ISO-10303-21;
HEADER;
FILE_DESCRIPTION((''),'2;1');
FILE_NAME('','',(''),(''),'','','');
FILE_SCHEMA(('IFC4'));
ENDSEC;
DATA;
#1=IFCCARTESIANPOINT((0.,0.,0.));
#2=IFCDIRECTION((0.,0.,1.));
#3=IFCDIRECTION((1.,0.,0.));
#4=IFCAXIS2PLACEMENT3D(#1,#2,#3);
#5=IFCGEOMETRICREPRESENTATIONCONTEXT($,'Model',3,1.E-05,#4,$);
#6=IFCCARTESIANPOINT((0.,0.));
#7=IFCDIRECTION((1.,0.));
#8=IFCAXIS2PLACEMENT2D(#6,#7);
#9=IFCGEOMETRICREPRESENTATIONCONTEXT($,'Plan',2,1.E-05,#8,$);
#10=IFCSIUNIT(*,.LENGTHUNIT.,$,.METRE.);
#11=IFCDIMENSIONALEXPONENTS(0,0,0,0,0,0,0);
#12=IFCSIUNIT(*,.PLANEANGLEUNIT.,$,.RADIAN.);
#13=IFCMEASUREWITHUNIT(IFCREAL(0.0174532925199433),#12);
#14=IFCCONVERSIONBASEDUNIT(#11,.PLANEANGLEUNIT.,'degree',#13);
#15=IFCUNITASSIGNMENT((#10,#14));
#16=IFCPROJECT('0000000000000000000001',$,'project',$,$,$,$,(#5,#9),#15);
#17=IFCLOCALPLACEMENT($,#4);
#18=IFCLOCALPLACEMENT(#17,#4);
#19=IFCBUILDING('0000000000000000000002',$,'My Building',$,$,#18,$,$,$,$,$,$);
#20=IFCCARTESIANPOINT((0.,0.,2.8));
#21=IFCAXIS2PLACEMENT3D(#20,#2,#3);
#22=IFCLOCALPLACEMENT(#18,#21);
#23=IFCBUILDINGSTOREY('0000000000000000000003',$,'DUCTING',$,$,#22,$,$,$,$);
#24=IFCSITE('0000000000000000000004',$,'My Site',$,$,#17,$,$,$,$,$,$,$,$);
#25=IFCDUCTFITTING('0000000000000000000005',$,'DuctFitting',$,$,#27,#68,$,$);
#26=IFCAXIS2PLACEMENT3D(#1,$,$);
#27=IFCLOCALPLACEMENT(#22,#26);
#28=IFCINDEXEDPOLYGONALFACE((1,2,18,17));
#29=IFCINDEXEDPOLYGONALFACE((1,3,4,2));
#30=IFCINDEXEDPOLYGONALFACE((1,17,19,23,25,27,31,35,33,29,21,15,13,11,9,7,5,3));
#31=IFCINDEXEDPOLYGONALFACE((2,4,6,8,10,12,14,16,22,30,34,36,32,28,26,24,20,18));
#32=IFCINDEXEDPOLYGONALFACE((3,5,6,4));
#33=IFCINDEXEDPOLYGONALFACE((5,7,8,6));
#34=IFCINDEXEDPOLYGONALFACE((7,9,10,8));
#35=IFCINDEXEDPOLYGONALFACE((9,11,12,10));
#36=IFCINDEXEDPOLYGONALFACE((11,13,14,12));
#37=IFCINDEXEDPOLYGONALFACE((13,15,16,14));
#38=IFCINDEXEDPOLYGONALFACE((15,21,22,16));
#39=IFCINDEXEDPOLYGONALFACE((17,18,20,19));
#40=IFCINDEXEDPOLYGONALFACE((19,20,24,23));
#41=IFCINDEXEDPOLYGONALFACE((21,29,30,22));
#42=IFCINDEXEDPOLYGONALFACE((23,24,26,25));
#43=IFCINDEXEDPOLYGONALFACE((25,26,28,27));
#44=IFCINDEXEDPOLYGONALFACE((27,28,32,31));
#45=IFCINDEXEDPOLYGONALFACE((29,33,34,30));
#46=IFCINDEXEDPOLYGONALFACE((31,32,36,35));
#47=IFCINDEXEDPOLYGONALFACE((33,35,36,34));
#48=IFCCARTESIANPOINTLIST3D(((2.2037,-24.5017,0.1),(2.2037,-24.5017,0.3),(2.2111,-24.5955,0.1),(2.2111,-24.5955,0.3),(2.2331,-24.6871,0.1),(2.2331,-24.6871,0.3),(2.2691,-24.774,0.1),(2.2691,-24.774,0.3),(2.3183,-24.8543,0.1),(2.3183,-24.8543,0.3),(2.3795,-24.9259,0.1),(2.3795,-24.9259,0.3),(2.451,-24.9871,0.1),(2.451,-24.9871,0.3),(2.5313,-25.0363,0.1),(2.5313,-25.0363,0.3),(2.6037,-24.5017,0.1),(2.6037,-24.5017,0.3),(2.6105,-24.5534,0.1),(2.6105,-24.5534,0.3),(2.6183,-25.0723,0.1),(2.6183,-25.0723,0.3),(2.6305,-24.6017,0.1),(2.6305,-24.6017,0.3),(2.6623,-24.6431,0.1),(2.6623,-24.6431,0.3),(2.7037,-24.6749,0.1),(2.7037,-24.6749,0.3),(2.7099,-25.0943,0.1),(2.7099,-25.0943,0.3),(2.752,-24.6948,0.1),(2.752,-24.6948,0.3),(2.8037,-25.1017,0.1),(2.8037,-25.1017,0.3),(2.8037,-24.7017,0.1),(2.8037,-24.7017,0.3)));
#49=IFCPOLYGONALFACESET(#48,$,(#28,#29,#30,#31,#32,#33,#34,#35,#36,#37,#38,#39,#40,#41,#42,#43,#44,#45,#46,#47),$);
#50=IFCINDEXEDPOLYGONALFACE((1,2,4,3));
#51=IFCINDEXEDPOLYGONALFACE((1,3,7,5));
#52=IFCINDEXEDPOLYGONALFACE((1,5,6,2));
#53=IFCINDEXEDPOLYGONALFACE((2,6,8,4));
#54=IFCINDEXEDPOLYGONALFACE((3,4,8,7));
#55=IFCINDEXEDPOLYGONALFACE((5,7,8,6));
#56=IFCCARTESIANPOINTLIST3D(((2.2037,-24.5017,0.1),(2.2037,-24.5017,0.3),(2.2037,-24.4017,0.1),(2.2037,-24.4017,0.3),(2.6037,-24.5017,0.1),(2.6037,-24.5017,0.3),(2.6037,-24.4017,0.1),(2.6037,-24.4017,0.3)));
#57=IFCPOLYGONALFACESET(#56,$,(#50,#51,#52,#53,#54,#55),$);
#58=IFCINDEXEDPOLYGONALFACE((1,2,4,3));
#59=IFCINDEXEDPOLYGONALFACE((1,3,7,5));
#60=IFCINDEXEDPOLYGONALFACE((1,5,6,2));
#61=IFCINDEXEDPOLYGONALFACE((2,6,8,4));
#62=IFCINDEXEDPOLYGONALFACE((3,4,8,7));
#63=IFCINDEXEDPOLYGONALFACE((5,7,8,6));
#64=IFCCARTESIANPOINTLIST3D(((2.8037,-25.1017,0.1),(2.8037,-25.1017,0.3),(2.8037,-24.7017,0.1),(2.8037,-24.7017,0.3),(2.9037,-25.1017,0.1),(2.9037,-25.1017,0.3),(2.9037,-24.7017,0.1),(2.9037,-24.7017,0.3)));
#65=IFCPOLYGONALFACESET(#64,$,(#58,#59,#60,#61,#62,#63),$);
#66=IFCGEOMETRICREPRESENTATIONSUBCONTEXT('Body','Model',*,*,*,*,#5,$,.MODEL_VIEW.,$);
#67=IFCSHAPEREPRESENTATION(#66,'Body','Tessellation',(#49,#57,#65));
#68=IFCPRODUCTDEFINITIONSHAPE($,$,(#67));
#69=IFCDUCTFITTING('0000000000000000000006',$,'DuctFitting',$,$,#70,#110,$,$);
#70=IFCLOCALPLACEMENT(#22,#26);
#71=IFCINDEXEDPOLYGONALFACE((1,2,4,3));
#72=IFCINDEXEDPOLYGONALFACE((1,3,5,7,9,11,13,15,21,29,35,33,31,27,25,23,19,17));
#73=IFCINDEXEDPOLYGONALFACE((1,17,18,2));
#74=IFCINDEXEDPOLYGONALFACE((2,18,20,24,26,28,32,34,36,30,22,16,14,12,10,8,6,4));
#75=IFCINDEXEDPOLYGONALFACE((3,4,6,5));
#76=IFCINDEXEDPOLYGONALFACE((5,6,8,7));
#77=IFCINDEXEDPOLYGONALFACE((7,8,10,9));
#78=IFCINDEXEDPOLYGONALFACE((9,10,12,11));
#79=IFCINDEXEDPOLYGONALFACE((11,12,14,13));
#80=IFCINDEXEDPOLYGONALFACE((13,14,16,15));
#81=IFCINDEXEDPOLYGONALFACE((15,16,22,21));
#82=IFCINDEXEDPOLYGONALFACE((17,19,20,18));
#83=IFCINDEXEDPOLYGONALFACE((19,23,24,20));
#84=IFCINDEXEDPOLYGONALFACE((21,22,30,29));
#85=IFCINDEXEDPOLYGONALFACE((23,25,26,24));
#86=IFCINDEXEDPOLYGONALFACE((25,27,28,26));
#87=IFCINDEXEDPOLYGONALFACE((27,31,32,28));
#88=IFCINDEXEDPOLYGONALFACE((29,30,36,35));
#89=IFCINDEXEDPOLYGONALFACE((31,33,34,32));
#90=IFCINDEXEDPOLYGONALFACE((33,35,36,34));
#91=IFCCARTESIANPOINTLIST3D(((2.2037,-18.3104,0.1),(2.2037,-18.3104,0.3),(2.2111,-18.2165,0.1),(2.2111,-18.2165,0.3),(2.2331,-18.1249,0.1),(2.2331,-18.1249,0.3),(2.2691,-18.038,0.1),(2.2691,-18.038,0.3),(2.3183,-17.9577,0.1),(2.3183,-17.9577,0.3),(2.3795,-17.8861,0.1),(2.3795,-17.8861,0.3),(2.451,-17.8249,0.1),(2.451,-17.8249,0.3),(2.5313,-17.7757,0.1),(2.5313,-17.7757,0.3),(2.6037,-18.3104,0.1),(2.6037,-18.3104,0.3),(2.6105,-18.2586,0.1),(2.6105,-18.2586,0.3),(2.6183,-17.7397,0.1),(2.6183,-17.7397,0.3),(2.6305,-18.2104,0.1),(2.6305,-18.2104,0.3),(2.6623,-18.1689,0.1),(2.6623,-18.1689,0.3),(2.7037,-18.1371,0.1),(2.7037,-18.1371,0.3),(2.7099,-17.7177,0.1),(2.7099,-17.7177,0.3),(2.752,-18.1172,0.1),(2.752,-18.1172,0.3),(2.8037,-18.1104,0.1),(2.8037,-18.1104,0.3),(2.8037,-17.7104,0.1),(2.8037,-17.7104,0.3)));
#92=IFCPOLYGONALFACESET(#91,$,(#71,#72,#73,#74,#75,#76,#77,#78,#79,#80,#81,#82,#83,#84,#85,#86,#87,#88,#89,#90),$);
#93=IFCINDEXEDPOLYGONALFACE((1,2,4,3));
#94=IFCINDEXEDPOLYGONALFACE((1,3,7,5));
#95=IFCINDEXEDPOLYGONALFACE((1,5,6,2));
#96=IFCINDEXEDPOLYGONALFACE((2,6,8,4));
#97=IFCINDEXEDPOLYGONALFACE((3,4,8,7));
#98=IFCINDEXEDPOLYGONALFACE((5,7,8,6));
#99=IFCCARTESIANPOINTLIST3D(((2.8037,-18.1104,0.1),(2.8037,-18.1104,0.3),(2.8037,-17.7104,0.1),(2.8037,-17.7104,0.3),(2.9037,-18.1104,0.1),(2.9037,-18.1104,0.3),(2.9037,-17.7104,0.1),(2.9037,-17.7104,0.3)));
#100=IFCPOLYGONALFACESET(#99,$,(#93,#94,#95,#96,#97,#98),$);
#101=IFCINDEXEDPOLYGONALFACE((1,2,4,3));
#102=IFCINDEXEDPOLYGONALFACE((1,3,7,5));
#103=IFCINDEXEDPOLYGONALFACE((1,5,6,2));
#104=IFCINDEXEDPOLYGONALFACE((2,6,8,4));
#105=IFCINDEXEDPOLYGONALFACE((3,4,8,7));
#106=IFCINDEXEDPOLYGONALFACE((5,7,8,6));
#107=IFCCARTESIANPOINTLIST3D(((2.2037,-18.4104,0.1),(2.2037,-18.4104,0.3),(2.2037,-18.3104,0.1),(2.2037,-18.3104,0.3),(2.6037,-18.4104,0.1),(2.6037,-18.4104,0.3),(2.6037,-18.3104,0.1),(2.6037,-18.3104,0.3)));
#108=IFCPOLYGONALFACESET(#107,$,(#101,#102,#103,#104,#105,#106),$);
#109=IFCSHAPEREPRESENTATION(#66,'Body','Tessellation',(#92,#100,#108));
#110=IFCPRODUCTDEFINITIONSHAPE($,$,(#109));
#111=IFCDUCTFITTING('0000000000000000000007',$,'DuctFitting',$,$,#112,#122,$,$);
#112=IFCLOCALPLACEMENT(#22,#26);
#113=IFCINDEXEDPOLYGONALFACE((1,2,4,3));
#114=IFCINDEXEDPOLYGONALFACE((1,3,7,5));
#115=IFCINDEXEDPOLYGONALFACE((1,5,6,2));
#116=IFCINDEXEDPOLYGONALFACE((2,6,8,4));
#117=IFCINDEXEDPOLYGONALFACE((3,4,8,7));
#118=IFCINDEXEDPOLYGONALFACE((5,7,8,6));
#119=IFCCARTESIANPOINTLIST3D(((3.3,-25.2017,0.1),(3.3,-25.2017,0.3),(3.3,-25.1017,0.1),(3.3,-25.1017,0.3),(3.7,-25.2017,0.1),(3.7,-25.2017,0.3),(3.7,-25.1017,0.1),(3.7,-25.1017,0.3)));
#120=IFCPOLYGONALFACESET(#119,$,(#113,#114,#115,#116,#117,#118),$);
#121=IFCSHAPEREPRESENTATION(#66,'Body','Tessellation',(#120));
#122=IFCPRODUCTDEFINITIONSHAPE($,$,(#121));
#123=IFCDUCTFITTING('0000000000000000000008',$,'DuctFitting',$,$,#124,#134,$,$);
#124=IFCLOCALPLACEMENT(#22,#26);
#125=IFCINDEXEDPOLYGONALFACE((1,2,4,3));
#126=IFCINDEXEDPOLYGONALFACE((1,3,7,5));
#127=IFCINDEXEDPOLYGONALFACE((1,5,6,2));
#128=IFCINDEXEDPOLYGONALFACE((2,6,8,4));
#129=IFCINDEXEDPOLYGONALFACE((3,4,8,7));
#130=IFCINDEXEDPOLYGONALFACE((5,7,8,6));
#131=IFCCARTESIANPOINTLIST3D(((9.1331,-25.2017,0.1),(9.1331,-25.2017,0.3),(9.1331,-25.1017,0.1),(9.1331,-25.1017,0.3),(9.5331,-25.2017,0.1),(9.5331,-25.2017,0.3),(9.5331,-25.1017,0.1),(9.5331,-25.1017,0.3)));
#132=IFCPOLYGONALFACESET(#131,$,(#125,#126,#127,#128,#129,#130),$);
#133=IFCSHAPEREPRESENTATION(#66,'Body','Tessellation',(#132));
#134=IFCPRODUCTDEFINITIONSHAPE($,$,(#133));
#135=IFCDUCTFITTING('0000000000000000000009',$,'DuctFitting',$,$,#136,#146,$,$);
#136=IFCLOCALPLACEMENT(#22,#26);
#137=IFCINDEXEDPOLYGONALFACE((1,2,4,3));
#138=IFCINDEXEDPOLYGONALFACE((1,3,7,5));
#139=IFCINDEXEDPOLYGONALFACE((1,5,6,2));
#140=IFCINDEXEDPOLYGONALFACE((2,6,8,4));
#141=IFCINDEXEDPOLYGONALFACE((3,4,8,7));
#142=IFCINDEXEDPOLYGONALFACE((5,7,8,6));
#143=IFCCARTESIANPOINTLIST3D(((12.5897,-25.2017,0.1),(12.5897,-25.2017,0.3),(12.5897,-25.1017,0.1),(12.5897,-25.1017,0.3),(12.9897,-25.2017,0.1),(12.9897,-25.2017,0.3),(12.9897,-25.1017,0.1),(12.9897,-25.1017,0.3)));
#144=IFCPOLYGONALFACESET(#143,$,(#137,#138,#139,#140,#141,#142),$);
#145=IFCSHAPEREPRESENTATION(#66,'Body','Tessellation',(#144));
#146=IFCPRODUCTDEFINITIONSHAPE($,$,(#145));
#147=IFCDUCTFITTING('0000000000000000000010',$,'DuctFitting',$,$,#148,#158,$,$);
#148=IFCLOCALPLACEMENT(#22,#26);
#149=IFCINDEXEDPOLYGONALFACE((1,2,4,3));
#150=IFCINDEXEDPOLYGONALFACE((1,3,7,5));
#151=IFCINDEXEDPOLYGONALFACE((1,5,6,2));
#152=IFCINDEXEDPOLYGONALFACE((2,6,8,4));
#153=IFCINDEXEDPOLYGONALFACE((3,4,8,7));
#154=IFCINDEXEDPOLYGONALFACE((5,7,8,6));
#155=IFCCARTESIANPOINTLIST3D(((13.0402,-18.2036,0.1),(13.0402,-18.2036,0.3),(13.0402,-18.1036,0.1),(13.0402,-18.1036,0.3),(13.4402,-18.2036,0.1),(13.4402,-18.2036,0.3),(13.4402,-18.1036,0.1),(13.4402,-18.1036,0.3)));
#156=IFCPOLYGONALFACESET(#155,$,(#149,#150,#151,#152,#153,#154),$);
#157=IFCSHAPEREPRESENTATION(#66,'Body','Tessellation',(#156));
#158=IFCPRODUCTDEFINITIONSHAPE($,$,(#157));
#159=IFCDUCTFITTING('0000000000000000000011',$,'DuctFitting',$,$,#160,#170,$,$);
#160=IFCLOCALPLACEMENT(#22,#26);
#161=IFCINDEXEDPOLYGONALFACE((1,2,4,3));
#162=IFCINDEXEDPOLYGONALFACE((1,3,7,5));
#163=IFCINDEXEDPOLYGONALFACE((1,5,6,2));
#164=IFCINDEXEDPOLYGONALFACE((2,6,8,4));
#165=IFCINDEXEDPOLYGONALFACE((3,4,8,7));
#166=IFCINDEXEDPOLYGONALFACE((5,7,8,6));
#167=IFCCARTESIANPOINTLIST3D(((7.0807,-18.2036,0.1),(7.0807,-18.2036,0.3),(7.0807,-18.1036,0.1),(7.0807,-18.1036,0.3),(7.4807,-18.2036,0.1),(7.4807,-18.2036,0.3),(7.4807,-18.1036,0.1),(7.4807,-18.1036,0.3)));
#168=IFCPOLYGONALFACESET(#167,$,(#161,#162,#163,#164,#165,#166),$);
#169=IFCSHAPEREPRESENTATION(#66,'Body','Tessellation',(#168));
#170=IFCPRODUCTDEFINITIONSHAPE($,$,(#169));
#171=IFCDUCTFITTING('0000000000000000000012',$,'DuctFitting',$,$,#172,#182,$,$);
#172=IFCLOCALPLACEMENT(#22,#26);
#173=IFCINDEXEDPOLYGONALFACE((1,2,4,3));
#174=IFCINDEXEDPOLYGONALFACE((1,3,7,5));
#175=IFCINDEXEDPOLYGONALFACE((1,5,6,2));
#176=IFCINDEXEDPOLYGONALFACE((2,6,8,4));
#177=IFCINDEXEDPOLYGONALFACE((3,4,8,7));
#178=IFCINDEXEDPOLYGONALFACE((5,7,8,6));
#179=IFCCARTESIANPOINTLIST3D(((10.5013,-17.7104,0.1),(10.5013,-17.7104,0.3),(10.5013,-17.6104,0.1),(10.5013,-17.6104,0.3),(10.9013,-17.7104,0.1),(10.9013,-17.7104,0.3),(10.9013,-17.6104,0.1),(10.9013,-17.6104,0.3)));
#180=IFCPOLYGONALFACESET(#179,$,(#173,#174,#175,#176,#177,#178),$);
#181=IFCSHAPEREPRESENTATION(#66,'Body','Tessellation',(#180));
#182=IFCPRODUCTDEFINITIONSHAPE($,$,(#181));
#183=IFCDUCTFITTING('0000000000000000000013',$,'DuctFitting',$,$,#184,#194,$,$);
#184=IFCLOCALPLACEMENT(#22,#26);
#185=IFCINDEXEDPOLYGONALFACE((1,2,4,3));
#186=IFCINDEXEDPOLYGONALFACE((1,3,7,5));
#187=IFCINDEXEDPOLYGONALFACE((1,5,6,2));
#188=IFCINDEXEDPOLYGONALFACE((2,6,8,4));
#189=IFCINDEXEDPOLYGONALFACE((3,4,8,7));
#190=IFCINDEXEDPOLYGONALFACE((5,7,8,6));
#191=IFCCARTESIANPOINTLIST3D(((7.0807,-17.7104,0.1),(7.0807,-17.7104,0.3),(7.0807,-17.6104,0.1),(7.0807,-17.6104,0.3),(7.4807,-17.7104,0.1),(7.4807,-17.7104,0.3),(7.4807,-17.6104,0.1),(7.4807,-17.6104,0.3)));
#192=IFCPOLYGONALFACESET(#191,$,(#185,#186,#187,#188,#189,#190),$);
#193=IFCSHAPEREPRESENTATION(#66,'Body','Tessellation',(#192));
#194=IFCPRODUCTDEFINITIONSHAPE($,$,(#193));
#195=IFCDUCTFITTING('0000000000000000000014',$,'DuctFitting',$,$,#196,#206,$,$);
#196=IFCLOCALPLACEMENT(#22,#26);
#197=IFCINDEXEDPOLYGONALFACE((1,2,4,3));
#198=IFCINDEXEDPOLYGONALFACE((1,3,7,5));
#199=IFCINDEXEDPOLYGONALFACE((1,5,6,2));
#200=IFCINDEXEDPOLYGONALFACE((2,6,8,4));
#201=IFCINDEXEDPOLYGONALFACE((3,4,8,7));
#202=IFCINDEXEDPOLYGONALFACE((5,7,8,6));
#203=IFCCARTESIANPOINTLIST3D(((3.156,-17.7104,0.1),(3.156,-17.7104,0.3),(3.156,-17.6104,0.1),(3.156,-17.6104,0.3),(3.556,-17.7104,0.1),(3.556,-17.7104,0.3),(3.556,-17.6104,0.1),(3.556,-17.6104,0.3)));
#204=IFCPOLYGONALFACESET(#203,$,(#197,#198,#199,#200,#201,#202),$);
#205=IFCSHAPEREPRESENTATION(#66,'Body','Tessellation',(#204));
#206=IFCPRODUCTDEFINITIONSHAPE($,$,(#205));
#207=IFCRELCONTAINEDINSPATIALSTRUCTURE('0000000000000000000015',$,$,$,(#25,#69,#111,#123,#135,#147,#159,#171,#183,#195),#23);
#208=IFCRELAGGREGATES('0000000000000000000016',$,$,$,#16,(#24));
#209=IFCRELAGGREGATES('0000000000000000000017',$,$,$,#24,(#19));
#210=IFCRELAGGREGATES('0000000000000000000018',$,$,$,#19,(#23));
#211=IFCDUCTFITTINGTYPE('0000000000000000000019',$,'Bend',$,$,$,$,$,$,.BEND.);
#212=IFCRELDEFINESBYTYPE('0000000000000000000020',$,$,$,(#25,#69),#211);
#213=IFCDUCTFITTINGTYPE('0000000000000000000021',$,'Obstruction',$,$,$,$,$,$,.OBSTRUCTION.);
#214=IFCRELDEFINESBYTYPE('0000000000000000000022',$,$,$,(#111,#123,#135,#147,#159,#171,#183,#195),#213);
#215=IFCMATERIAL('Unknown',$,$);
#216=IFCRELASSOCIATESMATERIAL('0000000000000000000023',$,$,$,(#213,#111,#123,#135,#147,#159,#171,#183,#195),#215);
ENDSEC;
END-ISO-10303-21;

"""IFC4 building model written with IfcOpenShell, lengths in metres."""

from ifc_helpers import new_model, entity, si_unit, converted_unit, frame, origin_with_axes, origin_2d_with_axis, place, context, subcontext, project, spatial, line, arc, indexed_curve, rectangle, outline, extrude, source, transform, mapped, material, material_profile, profile_set, profile_usage, type_object, type_shapes, element, save


model = new_model("IFC4")

# Units and contexts
model_context = context("Model", 3, precision=1e-05, world=origin_with_axes())
plan_context = context("Plan", 2, precision=1e-05, world=origin_2d_with_axis())
body_context = subcontext(model_context, "Body", "Model", "MODEL_VIEW")
ifc_project = project(units=[si_unit("LENGTHUNIT", "METRE"), converted_unit("PLANEANGLEUNIT", "degree", entity("IfcReal", 0.0174532925199433), si_unit("PLANEANGLEUNIT", "RADIAN"), dimensions=[0, 0, 0, 0, 0, 0, 0])], contexts=[model_context, plan_context])

# Site, building, storey
site_placement = place(None, origin_with_axes())
site = spatial("IfcSite", under=ifc_project, at=site_placement, Name="My Site")
building_placement = place(site_placement, origin_with_axes())
building = spatial("IfcBuilding", under=site, at=building_placement, Name="My Building")
storey_placement = place(building_placement, frame((0.0, 0.0, 2.8), z_axis=(0.0, 0.0, 1.0), x_axis=(1.0, 0.0, 0.0)))
storey = spatial("IfcBuildingStorey", under=building, at=storey_placement, Name="DUCTING")

# Shared definitions
ifc_material = material(Name="Unknown")

# Duct fittings
duct_fitting_type_1 = type_object("IfcDuctFittingType", Name="Bend", PredefinedType="BEND")
shared_shape = source(origin_with_axes(), body_context, "Body", "SweptSolid", [
    extrude(outline(indexed_curve([(0.2, 0.0), (0.2586, 0.1414), (0.4, 0.2), (0.4, 0.6), (-0.0243, 0.4243), (-0.2, 0.0)], segments=[arc(1, 2, 3), line(3, 4), arc(4, 5, 6), line(6, 1)])), frame((0.0, -0.1, 0.1), z_axis=(0.0, -1.0, 0.0), x_axis=(1.0, 0.0, 0.0)), (0.0, 0.0, -1.0), 0.2),
    extrude(rectangle(XDim=0.4, YDim=0.2), origin_with_axes(), (0.0, 0.0, 1.0), 0.1),
    extrude(rectangle(XDim=0.4, YDim=0.2), frame((0.4, 0.0, 0.5), z_axis=(1.0, 0.0, 0.0), x_axis=(0.0, 0.0, 1.0)), (0.0, 0.0, 1.0), 0.1),
])
type_shapes(duct_fitting_type_1, [shared_shape])
for number, where, z_axis, x_axis, name in (
    (1, (2.4037, -24.4017, 0.2), (0.0, -1.0, 0.0), (1.0, 0.0, 0.0), "DuctFitting"),
    (2, (2.9037, -17.9104, 0.2), (-1.0, 0.0, 0.0), (0.0, -1.0, 0.0), "DuctFitting"),
):
    element("IfcDuctFitting", number, at=place(storey_placement, frame(where, z_axis=z_axis, x_axis=x_axis)), inside=storey, type_object=duct_fitting_type_1, Name=name, context=body_context, shape_type="MappedRepresentation", body=[
        mapped(shared_shape, transform((0.0, 0.0, 0.0), x_axis=(1.0, 0.0, 0.0), y_axis=(0.0, 1.0, 0.0), z_axis=(0.0, 0.0, 1.0), scale=1.0)),
    ])
ifc_material_profile_1 = material_profile(ifc_material, rectangle(XDim=0.4, YDim=0.2))
ifc_profile_set_1 = profile_set([ifc_material_profile_1])
ifc_profile_usage_1 = profile_usage(ifc_profile_set_1, cardinal=5)
duct_fitting_type_2 = type_object("IfcDuctFittingType", Name="Obstruction", PredefinedType="OBSTRUCTION", material=ifc_profile_set_1)
duct_fitting_1_placement = place(storey_placement, frame((3.5, -25.1017, 0.2), z_axis=(0.0, -1.0, 0.0), x_axis=(1.0, 0.0, 0.0)))
element("IfcDuctFitting", 3, at=duct_fitting_1_placement, inside=storey, type_object=duct_fitting_type_2, material=ifc_profile_usage_1, Name="DuctFitting", context=body_context, shape_type="SweptSolid", body=[
    extrude(rectangle(XDim=0.4, YDim=0.2), origin_with_axes(), (0.0, 0.0, 1.0), 0.1),
])
ifc_profile_usage_2 = profile_usage(ifc_profile_set_1, cardinal=5)
duct_fitting_2_placement = place(storey_placement, frame((9.3331, -25.1017, 0.2), z_axis=(0.0, -1.0, 0.0), x_axis=(1.0, 0.0, 0.0)))
element("IfcDuctFitting", 4, at=duct_fitting_2_placement, inside=storey, type_object=duct_fitting_type_2, material=ifc_profile_usage_2, Name="DuctFitting", context=body_context, shape_type="SweptSolid", body=[
    extrude(rectangle(XDim=0.4, YDim=0.2), origin_with_axes(), (0.0, 0.0, 1.0), 0.1),
])
ifc_profile_usage_3 = profile_usage(ifc_profile_set_1, cardinal=5)
duct_fitting_3_placement = place(storey_placement, frame((12.7897, -25.1017, 0.2), z_axis=(0.0, -1.0, 0.0), x_axis=(1.0, 0.0, 0.0)))
element("IfcDuctFitting", 5, at=duct_fitting_3_placement, inside=storey, type_object=duct_fitting_type_2, material=ifc_profile_usage_3, Name="DuctFitting", context=body_context, shape_type="SweptSolid", body=[
    extrude(rectangle(XDim=0.4, YDim=0.2), origin_with_axes(), (0.0, 0.0, 1.0), 0.1),
])
ifc_profile_usage_4 = profile_usage(ifc_profile_set_1, cardinal=5)
duct_fitting_4_placement = place(storey_placement, frame((13.2402, -18.1036, 0.2), z_axis=(0.0, -1.0, 0.0), x_axis=(1.0, 0.0, 0.0)))
element("IfcDuctFitting", 6, at=duct_fitting_4_placement, inside=storey, type_object=duct_fitting_type_2, material=ifc_profile_usage_4, Name="DuctFitting", context=body_context, shape_type="SweptSolid", body=[
    extrude(rectangle(XDim=0.4, YDim=0.2), origin_with_axes(), (0.0, 0.0, 1.0), 0.1),
])
ifc_profile_usage_5 = profile_usage(ifc_profile_set_1, cardinal=5)
duct_fitting_5_placement = place(storey_placement, frame((7.2807, -18.1036, 0.2), z_axis=(0.0, -1.0, 0.0), x_axis=(1.0, 0.0, 0.0)))
element("IfcDuctFitting", 7, at=duct_fitting_5_placement, inside=storey, type_object=duct_fitting_type_2, material=ifc_profile_usage_5, Name="DuctFitting", context=body_context, shape_type="SweptSolid", body=[
    extrude(rectangle(XDim=0.4, YDim=0.2), origin_with_axes(), (0.0, 0.0, 1.0), 0.1),
])
ifc_profile_usage_6 = profile_usage(ifc_profile_set_1, cardinal=5)
duct_fitting_6_placement = place(storey_placement, frame((10.7013, -17.7104, 0.2), z_axis=(0.0, 1.0, 0.0), x_axis=(1.0, 0.0, 0.0)))
element("IfcDuctFitting", 8, at=duct_fitting_6_placement, inside=storey, type_object=duct_fitting_type_2, material=ifc_profile_usage_6, Name="DuctFitting", context=body_context, shape_type="SweptSolid", body=[
    extrude(rectangle(XDim=0.4, YDim=0.2), origin_with_axes(), (0.0, 0.0, 1.0), 0.1),
])
ifc_profile_usage_7 = profile_usage(ifc_profile_set_1, cardinal=5)
duct_fitting_7_placement = place(storey_placement, frame((7.2807, -17.7104, 0.2), z_axis=(0.0, 1.0, 0.0), x_axis=(1.0, 0.0, 0.0)))
element("IfcDuctFitting", 9, at=duct_fitting_7_placement, inside=storey, type_object=duct_fitting_type_2, material=ifc_profile_usage_7, Name="DuctFitting", context=body_context, shape_type="SweptSolid", body=[
    extrude(rectangle(XDim=0.4, YDim=0.2), origin_with_axes(), (0.0, 0.0, 1.0), 0.1),
])
ifc_profile_usage_8 = profile_usage(ifc_profile_set_1, cardinal=5)
duct_fitting_8_placement = place(storey_placement, frame((3.356, -17.7104, 0.2), z_axis=(0.0, 1.0, 0.0), x_axis=(1.0, 0.0, 0.0)))
element("IfcDuctFitting", 10, at=duct_fitting_8_placement, inside=storey, type_object=duct_fitting_type_2, material=ifc_profile_usage_8, Name="DuctFitting", context=body_context, shape_type="SweptSolid", body=[
    extrude(rectangle(XDim=0.4, YDim=0.2), origin_with_axes(), (0.0, 0.0, 1.0), 0.1),
])

save(model, "model.ifc")
